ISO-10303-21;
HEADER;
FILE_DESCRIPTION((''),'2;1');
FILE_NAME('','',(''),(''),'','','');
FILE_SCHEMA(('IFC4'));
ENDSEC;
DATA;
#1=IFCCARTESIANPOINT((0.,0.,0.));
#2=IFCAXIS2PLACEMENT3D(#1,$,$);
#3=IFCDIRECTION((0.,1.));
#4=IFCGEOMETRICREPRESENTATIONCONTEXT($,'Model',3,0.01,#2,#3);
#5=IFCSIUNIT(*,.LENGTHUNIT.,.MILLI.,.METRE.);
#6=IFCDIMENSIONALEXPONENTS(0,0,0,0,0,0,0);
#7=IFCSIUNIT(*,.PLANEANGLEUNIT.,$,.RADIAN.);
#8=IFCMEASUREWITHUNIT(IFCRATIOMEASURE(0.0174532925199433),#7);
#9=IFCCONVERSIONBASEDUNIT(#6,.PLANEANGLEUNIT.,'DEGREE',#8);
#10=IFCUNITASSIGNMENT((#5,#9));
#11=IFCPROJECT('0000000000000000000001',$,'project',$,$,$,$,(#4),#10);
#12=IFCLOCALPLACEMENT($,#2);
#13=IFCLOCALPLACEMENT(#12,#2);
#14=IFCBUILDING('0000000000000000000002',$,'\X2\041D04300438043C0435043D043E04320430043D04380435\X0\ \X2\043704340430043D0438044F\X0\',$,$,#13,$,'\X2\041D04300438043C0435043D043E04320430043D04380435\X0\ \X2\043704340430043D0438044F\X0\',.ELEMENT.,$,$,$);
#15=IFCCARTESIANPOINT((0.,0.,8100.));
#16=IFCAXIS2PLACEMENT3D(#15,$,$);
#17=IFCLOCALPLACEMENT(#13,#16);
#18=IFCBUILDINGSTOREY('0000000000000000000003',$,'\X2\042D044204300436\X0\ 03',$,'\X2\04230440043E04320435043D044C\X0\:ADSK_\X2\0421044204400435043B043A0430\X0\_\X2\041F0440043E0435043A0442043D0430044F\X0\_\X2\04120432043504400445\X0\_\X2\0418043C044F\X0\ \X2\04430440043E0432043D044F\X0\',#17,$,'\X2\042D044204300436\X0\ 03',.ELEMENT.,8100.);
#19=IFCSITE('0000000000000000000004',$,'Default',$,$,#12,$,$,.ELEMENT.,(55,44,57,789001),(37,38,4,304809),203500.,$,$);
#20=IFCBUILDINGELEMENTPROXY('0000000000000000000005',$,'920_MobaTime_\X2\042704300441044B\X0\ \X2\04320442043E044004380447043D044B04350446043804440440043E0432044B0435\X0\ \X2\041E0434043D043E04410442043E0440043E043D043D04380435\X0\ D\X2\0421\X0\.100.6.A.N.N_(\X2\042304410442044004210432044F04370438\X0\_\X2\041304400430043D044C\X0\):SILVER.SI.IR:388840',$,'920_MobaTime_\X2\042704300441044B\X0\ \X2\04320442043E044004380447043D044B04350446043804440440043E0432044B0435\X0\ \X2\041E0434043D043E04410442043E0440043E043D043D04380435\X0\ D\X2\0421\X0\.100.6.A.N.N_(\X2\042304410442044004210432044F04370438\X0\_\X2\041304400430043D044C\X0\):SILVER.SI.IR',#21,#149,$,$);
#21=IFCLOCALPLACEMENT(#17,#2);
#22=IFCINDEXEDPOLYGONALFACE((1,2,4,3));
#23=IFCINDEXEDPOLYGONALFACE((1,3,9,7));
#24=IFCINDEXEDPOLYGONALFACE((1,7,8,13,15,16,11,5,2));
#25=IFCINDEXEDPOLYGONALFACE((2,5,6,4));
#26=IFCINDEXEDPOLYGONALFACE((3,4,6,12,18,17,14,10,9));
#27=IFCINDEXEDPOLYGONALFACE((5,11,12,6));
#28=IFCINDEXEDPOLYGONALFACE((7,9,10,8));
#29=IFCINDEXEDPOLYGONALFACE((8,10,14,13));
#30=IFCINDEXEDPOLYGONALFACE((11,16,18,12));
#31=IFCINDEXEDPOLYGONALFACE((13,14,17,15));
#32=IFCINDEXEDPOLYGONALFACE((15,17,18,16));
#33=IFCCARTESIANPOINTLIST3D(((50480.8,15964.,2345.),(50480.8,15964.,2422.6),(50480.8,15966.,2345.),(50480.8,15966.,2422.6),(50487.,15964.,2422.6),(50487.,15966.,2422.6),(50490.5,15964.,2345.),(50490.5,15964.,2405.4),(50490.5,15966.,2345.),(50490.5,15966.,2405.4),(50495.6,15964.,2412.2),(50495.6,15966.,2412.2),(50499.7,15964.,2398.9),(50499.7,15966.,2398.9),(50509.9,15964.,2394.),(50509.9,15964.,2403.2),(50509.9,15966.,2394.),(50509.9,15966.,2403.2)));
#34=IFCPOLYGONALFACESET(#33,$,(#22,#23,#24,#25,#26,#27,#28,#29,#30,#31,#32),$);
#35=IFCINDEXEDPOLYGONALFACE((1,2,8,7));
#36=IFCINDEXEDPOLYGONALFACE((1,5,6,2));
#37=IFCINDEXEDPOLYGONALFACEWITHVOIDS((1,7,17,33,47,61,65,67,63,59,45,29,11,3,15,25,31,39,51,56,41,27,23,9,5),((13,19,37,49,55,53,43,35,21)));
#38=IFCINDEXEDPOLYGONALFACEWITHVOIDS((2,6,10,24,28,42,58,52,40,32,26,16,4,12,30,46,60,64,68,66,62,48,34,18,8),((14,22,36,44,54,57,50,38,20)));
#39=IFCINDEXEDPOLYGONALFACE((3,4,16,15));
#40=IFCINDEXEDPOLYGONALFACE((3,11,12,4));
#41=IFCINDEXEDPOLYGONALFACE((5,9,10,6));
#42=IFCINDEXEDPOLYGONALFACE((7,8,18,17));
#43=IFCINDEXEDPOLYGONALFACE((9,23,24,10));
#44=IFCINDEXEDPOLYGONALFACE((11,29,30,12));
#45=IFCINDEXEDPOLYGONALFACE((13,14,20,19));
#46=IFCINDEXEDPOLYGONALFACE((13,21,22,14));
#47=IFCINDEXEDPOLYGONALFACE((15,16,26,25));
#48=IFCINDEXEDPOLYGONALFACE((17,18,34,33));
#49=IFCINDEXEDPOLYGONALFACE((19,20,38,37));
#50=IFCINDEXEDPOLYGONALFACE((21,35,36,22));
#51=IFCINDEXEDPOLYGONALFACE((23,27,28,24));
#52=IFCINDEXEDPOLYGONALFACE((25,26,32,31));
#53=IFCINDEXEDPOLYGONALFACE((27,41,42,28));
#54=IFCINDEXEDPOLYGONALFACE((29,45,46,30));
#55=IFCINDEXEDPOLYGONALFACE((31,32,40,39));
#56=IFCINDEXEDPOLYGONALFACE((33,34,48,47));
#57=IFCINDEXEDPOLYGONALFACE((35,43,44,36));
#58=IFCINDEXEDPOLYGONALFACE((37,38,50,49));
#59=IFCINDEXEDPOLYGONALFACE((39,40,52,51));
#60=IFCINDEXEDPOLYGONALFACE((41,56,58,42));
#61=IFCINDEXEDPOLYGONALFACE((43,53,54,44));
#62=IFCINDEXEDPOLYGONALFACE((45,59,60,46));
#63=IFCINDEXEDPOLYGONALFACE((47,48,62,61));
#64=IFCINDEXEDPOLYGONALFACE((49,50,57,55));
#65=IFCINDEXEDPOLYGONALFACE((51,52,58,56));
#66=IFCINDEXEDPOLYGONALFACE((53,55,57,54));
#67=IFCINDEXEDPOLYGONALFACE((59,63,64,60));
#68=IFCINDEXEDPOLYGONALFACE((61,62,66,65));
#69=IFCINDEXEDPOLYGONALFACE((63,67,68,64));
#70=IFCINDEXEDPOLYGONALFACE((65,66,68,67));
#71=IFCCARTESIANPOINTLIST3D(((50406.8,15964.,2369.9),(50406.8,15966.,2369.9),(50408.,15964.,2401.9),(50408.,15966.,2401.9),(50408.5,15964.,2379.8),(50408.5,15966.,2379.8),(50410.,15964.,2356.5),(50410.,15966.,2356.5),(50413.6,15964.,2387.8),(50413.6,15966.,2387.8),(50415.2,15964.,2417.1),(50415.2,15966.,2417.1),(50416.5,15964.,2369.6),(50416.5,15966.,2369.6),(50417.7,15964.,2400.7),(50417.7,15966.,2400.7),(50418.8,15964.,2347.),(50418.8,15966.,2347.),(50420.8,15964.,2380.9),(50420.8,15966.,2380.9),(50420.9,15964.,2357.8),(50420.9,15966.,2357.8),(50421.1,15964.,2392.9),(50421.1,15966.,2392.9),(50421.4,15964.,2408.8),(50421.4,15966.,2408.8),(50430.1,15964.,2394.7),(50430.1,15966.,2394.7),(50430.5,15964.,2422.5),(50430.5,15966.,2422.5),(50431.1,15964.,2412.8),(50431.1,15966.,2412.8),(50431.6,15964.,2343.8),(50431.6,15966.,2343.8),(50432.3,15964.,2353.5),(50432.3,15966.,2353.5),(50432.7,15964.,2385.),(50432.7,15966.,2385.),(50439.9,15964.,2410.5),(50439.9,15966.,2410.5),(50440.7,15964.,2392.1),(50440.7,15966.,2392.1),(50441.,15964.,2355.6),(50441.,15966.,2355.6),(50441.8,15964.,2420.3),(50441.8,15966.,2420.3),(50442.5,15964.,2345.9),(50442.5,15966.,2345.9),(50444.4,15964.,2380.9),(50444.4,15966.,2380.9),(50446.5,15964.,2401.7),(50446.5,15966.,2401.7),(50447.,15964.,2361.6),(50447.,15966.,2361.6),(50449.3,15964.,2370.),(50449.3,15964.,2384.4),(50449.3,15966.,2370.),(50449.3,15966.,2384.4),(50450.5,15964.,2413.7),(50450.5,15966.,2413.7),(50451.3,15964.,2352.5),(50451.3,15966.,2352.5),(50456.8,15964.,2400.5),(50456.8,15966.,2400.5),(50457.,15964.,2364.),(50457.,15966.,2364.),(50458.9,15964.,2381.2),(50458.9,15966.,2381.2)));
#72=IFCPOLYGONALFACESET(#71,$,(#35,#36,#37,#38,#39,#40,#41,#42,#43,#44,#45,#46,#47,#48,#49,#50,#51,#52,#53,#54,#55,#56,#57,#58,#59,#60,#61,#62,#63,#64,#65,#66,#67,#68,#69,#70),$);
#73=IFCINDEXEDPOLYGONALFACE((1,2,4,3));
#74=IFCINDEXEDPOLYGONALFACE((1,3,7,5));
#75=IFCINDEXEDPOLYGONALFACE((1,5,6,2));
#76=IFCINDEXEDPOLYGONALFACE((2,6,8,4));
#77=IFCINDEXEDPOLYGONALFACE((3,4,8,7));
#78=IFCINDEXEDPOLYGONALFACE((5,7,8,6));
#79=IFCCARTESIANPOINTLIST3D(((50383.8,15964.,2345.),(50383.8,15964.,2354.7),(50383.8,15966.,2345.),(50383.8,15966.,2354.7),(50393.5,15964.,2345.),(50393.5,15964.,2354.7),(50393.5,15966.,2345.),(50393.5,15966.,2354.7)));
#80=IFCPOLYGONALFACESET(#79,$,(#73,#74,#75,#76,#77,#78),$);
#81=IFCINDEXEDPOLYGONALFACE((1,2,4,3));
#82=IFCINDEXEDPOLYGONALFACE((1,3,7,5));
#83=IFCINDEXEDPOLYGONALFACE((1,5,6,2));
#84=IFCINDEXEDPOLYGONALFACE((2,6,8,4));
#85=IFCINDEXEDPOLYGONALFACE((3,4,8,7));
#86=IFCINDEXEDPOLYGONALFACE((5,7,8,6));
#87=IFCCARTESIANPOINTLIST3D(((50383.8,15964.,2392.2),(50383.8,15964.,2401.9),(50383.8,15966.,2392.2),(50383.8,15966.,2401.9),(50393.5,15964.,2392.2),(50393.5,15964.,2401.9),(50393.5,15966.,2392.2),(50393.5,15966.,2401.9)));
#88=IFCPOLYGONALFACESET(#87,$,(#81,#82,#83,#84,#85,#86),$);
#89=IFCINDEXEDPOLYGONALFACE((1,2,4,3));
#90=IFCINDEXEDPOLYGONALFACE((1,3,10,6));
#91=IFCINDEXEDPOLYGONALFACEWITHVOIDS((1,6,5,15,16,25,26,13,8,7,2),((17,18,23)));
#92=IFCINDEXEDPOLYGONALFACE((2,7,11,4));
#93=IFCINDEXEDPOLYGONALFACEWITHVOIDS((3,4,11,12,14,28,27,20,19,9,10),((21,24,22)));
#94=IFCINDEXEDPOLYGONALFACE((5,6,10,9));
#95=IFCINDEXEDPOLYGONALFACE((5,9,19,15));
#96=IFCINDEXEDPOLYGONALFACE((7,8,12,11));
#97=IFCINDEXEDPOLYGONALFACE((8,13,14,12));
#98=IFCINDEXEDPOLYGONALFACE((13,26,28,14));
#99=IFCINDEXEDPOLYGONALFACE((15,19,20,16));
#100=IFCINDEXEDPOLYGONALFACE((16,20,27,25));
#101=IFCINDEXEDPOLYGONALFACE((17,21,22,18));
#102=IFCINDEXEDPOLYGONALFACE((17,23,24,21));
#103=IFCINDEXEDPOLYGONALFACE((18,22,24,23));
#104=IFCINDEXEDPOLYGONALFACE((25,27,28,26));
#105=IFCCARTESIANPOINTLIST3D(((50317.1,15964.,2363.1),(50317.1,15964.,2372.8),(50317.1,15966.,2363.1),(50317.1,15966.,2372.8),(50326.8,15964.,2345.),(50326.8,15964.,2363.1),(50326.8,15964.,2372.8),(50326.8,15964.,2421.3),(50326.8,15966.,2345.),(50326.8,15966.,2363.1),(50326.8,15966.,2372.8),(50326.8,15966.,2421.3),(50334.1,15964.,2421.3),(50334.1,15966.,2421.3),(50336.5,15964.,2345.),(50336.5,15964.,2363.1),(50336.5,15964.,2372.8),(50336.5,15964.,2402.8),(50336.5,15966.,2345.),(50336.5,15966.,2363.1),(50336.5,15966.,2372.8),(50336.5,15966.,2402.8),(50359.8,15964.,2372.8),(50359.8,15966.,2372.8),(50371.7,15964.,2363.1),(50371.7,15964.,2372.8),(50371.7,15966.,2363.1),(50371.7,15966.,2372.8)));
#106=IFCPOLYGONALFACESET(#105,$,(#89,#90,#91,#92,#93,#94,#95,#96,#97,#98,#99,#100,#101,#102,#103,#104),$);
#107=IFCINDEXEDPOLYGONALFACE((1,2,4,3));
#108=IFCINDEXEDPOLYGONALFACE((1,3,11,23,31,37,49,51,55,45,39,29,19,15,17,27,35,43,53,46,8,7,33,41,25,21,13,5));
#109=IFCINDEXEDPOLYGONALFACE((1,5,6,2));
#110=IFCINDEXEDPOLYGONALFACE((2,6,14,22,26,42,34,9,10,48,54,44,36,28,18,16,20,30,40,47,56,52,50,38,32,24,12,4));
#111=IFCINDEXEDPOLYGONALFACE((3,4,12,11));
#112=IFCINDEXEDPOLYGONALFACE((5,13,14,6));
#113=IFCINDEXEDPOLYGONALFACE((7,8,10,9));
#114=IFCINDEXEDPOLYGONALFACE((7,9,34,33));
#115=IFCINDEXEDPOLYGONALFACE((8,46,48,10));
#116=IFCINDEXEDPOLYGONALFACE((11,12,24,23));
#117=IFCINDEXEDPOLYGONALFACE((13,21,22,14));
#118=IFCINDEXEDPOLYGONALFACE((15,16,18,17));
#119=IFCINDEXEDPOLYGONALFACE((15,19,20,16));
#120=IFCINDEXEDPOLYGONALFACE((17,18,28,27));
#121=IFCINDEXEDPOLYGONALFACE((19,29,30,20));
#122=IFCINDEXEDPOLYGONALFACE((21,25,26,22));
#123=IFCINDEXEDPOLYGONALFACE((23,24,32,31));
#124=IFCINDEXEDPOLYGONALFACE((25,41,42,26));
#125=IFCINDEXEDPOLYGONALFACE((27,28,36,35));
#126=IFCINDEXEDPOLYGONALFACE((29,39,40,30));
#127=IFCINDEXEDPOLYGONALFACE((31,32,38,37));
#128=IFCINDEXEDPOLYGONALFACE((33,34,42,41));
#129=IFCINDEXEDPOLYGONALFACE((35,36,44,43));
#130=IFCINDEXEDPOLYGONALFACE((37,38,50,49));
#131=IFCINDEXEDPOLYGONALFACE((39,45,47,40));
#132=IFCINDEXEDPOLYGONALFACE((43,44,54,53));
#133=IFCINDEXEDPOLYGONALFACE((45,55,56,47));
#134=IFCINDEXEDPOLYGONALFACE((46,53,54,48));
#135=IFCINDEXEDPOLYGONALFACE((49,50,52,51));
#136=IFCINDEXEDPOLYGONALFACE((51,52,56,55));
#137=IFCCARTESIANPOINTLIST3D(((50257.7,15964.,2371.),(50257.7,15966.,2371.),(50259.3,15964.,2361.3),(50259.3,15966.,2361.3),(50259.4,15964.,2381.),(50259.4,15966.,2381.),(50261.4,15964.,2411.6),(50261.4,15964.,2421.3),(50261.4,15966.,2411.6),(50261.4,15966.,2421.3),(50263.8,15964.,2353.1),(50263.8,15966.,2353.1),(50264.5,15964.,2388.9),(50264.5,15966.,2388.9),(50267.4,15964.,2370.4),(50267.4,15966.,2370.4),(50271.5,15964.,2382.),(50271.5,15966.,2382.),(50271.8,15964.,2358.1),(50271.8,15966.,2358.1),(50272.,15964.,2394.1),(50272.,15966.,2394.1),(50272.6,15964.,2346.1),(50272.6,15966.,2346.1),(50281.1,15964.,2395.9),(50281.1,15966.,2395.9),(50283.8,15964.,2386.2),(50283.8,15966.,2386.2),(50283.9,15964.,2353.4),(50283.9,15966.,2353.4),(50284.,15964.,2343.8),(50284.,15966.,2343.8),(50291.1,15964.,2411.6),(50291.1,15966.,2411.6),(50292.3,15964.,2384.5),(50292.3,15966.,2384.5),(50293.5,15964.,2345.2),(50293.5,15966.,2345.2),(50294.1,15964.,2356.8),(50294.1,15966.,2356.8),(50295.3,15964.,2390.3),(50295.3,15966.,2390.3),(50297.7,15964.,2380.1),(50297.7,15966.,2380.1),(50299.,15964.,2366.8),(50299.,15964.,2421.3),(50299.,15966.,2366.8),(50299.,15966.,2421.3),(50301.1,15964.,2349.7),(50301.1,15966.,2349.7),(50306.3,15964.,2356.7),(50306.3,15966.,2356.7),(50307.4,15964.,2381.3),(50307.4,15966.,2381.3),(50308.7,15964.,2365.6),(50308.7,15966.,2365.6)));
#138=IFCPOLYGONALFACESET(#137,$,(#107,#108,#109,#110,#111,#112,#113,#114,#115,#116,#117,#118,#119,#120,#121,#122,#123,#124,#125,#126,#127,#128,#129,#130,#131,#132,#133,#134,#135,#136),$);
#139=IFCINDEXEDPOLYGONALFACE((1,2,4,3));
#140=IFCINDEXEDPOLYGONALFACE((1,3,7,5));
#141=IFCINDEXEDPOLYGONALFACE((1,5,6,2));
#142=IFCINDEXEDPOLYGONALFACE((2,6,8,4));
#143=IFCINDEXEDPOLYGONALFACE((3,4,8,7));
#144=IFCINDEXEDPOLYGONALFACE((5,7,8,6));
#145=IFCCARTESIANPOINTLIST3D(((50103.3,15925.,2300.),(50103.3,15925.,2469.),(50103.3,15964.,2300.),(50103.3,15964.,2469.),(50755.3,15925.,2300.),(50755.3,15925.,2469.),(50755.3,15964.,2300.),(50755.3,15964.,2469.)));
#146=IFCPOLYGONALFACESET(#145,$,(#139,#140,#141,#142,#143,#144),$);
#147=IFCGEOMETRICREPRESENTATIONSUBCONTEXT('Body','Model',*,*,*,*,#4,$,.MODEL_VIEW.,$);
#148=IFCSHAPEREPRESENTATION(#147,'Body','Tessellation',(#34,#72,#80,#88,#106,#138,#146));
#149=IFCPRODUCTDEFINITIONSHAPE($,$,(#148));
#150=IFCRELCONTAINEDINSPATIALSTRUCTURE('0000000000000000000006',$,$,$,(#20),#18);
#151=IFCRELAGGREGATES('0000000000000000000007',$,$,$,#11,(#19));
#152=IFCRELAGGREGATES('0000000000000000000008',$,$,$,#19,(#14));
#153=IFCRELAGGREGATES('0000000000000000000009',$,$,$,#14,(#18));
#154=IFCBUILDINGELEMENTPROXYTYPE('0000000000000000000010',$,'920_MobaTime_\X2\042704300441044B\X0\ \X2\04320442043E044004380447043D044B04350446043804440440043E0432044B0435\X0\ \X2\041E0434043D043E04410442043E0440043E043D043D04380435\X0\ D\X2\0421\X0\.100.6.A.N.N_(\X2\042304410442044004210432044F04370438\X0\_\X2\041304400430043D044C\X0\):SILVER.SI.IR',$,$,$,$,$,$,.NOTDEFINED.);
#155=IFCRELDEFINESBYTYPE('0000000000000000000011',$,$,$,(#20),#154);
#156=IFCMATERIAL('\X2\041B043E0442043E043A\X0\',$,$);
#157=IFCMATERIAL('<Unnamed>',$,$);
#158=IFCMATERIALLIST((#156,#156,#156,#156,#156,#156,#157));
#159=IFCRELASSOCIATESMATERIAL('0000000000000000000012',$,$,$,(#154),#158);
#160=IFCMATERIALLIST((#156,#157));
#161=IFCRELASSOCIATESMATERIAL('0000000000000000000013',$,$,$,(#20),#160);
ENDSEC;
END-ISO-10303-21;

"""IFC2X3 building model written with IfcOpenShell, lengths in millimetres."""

from ifc_helpers import new_model, entity, si_unit, converted_unit, direction, frame, origin, origin_2d_with_axis, place, context, subcontext, project, spatial, polyline, rectangle, outline, extrude, source, transform, mapped, material, material_list, type_object, type_shapes, element, save


model = new_model("IFC2X3")

# Units and contexts
model_context = context("Model", 3, precision=0.01, world=origin(), true_north=direction((0.0, 1.0)))
body_context = subcontext(model_context, "Body", "Model", "MODEL_VIEW")
ifc_project = project(units=[si_unit("LENGTHUNIT", "METRE", prefix="MILLI"), converted_unit("PLANEANGLEUNIT", "DEGREE", entity("IfcRatioMeasure", 0.0174532925199433), si_unit("PLANEANGLEUNIT", "RADIAN"), dimensions=[0, 0, 0, 0, 0, 0, 0])], contexts=[model_context])

# Site, building, storey
site_placement = place(None, origin())
site = spatial("IfcSite", under=ifc_project, at=site_placement, Name="Default", CompositionType="ELEMENT", RefLatitude=(55, 44, 57, 789001), RefLongitude=(37, 38, 4, 304809), RefElevation=203500.0)
building_placement = place(site_placement, origin())
building = spatial("IfcBuilding", under=site, at=building_placement, Name="Наименование здания", LongName="Наименование здания", CompositionType="ELEMENT")
storey_placement = place(building_placement, frame((0.0, 0.0, 8100.0)))
storey = spatial("IfcBuildingStorey", under=building, at=storey_placement, Name="Этаж 03", ObjectType="Уровень:ADSK_Стрелка_Проектная_Вверх_Имя уровня", LongName="Этаж 03", CompositionType="ELEMENT", Elevation=8100.0)

# Building element proxy
ifc_material_1 = material(Name="Лоток")
ifc_material_2 = material(Name="<Unnamed>")
ifc_material_list_1 = material_list([ifc_material_1, ifc_material_1, ifc_material_1, ifc_material_1, ifc_material_1, ifc_material_1, ifc_material_2])
building_element_proxy_type = type_object("IfcBuildingElementProxyType", Name="920_MobaTime_Часы вторичныецифровые Односторонние DС.100.6.A.N.N_(УстрСвязи_Грань):SILVER.SI.IR", PredefinedType="NOTDEFINED", material=ifc_material_list_1)
shared_shape = source(origin(), body_context, "Body", "SweptSolid", [
    extrude(outline(polyline([(-49.3, -13.1), (28.2, -13.1), (28.2, -6.8), (17.9, 1.8), (8.8, 16.0), (-0.3, 16.0), (4.6, 5.8), (11.1, -3.4), (-49.3, -3.4), (-49.3, -13.1)])), frame((-64.6, 9.8, 39.0), z_axis=(0.0, 0.0, 1.0), x_axis=(0.0, 1.0, 0.0)), (0.0, 0.0, 1.0), 2.0),
    extrude(outline(polyline([(2.2, -27.6), (19.0, -27.6), (30.5, -16.1), (33.3, -4.9), (31.0, 5.8), (21.8, 17.2), (5.2, 27.3), (-11.1, 33.0), (-24.0, 32.7), (-33.6, 27.6), (-40.3, 18.6), (-42.8, 5.7), (-38.0, -6.3), (-27.2, -14.9), (-17.5, -17.7), (-8.2, -16.4), (-0.3, -11.9), (5.1, -4.5), (7.3, 6.2), (4.0, 17.2), (18.4, 7.3), (23.6, -2.4), (22.0, -11.4), (14.2, -18.4), (5.3, -18.3), (2.2, -27.6)]), holes=[polyline([(-9.0, 23.3), (-1.3, 14.3), (-2.5, 2.0), (-11.4, -7.0), (-23.4, -6.0), (-32.2, 2.9), (-31.2, 15.1), (-25.6, 22.1), (-17.5, 24.9), (-9.0, 23.3)])]), frame((-2.7, 3.6, 39.0), z_axis=(0.0, 0.0, 1.0), x_axis=(-0.427649, 0.903945, 0.0)), (0.0, 0.0, 1.0), 2.0),
    extrude(rectangle(XDim=9.7, YDim=9.7, at=origin_2d_with_axis()), frame((40.6, -34.7, 39.0)), (0.0, 0.0, 1.0), 2.0),
    extrude(rectangle(XDim=9.7, YDim=9.7, at=origin_2d_with_axis()), frame((40.6, 12.6, 39.0)), (0.0, 0.0, 1.0), 2.0),
    extrude(outline(polyline([(-0.9, -28.1), (8.8, -28.1), (8.8, -9.9), (18.5, -9.9), (18.5, -0.2), (8.8, -0.2), (8.8, 48.3), (1.5, 48.3), (-36.0, -0.2), (-36.0, -9.9), (-0.9, -9.9), (-0.9, -28.1)]), holes=[polyline([(-0.9, -0.2), (-24.1, -0.2), (-0.9, 29.7), (-0.9, -0.2)])]), frame((93.6, -11.4, 39.0)), (0.0, 0.0, 1.0), 2.0),
    extrude(outline(polyline([(3.3, -28.3), (12.5, -28.3), (20.5, -25.0), (26.8, -18.9), (30.7, -10.0), (31.4, 1.6), (26.9, 11.8), (20.1, 18.4), (11.1, 22.3), (1.0, 23.3), (-7.9, 20.4), (-14.9, 14.5), (-18.9, 6.2), (-17.1, -9.0), (-36.7, 0.5), (-29.1, 29.2), (-38.5, 31.7), (-48.1, -4.6), (-11.6, -23.1), (-8.0, -14.0), (-10.8, -7.6), (-10.2, 1.1), (-3.0, 11.8), (9.2, 12.8), (20.0, 5.5), (21.4, -7.5), (15.5, -16.4), (4.6, -18.6), (3.3, -28.3)])), frame((147.1, -8.5, 39.0), z_axis=(0.0, 0.0, 1.0), x_axis=(0.256974, -0.966418, 0.0)), (0.0, 0.0, 1.0), 2.0),
    extrude(rectangle(XDim=652.0, YDim=169.0, at=origin_2d_with_axis()), frame((0.0, 0.0, 0.0), z_axis=(0.0, 0.0, 1.0), x_axis=(-1.0, 0.0, 0.0)), (0.0, 0.0, 1.0), 39.0),
])
type_shapes(building_element_proxy_type, [shared_shape])
ifc_material_list_2 = material_list([ifc_material_1, ifc_material_2])
for number, where, z_axis, x_axis, name in (
    (1, (50429.3, 15925.0, 2384.5), (0.0, 1.0, 0.0), (-1.0, 0.0, 0.0), "920_MobaTime_Часы вторичныецифровые Односторонние DС.100.6.A.N.N_(УстрСвязи_Грань):SILVER.SI.IR:388840"),
):
    element("IfcBuildingElementProxy", number, at=place(storey_placement, frame(where, z_axis=z_axis, x_axis=x_axis)), inside=storey, type_object=building_element_proxy_type, material=ifc_material_list_2, Name=name, ObjectType="920_MobaTime_Часы вторичныецифровые Односторонние DС.100.6.A.N.N_(УстрСвязи_Грань):SILVER.SI.IR", context=body_context, shape_type="MappedRepresentation", body=[
        mapped(shared_shape, transform((0.0, 0.0, 0.0), scale=1.0)),
    ])

save(model, "model.ifc")
